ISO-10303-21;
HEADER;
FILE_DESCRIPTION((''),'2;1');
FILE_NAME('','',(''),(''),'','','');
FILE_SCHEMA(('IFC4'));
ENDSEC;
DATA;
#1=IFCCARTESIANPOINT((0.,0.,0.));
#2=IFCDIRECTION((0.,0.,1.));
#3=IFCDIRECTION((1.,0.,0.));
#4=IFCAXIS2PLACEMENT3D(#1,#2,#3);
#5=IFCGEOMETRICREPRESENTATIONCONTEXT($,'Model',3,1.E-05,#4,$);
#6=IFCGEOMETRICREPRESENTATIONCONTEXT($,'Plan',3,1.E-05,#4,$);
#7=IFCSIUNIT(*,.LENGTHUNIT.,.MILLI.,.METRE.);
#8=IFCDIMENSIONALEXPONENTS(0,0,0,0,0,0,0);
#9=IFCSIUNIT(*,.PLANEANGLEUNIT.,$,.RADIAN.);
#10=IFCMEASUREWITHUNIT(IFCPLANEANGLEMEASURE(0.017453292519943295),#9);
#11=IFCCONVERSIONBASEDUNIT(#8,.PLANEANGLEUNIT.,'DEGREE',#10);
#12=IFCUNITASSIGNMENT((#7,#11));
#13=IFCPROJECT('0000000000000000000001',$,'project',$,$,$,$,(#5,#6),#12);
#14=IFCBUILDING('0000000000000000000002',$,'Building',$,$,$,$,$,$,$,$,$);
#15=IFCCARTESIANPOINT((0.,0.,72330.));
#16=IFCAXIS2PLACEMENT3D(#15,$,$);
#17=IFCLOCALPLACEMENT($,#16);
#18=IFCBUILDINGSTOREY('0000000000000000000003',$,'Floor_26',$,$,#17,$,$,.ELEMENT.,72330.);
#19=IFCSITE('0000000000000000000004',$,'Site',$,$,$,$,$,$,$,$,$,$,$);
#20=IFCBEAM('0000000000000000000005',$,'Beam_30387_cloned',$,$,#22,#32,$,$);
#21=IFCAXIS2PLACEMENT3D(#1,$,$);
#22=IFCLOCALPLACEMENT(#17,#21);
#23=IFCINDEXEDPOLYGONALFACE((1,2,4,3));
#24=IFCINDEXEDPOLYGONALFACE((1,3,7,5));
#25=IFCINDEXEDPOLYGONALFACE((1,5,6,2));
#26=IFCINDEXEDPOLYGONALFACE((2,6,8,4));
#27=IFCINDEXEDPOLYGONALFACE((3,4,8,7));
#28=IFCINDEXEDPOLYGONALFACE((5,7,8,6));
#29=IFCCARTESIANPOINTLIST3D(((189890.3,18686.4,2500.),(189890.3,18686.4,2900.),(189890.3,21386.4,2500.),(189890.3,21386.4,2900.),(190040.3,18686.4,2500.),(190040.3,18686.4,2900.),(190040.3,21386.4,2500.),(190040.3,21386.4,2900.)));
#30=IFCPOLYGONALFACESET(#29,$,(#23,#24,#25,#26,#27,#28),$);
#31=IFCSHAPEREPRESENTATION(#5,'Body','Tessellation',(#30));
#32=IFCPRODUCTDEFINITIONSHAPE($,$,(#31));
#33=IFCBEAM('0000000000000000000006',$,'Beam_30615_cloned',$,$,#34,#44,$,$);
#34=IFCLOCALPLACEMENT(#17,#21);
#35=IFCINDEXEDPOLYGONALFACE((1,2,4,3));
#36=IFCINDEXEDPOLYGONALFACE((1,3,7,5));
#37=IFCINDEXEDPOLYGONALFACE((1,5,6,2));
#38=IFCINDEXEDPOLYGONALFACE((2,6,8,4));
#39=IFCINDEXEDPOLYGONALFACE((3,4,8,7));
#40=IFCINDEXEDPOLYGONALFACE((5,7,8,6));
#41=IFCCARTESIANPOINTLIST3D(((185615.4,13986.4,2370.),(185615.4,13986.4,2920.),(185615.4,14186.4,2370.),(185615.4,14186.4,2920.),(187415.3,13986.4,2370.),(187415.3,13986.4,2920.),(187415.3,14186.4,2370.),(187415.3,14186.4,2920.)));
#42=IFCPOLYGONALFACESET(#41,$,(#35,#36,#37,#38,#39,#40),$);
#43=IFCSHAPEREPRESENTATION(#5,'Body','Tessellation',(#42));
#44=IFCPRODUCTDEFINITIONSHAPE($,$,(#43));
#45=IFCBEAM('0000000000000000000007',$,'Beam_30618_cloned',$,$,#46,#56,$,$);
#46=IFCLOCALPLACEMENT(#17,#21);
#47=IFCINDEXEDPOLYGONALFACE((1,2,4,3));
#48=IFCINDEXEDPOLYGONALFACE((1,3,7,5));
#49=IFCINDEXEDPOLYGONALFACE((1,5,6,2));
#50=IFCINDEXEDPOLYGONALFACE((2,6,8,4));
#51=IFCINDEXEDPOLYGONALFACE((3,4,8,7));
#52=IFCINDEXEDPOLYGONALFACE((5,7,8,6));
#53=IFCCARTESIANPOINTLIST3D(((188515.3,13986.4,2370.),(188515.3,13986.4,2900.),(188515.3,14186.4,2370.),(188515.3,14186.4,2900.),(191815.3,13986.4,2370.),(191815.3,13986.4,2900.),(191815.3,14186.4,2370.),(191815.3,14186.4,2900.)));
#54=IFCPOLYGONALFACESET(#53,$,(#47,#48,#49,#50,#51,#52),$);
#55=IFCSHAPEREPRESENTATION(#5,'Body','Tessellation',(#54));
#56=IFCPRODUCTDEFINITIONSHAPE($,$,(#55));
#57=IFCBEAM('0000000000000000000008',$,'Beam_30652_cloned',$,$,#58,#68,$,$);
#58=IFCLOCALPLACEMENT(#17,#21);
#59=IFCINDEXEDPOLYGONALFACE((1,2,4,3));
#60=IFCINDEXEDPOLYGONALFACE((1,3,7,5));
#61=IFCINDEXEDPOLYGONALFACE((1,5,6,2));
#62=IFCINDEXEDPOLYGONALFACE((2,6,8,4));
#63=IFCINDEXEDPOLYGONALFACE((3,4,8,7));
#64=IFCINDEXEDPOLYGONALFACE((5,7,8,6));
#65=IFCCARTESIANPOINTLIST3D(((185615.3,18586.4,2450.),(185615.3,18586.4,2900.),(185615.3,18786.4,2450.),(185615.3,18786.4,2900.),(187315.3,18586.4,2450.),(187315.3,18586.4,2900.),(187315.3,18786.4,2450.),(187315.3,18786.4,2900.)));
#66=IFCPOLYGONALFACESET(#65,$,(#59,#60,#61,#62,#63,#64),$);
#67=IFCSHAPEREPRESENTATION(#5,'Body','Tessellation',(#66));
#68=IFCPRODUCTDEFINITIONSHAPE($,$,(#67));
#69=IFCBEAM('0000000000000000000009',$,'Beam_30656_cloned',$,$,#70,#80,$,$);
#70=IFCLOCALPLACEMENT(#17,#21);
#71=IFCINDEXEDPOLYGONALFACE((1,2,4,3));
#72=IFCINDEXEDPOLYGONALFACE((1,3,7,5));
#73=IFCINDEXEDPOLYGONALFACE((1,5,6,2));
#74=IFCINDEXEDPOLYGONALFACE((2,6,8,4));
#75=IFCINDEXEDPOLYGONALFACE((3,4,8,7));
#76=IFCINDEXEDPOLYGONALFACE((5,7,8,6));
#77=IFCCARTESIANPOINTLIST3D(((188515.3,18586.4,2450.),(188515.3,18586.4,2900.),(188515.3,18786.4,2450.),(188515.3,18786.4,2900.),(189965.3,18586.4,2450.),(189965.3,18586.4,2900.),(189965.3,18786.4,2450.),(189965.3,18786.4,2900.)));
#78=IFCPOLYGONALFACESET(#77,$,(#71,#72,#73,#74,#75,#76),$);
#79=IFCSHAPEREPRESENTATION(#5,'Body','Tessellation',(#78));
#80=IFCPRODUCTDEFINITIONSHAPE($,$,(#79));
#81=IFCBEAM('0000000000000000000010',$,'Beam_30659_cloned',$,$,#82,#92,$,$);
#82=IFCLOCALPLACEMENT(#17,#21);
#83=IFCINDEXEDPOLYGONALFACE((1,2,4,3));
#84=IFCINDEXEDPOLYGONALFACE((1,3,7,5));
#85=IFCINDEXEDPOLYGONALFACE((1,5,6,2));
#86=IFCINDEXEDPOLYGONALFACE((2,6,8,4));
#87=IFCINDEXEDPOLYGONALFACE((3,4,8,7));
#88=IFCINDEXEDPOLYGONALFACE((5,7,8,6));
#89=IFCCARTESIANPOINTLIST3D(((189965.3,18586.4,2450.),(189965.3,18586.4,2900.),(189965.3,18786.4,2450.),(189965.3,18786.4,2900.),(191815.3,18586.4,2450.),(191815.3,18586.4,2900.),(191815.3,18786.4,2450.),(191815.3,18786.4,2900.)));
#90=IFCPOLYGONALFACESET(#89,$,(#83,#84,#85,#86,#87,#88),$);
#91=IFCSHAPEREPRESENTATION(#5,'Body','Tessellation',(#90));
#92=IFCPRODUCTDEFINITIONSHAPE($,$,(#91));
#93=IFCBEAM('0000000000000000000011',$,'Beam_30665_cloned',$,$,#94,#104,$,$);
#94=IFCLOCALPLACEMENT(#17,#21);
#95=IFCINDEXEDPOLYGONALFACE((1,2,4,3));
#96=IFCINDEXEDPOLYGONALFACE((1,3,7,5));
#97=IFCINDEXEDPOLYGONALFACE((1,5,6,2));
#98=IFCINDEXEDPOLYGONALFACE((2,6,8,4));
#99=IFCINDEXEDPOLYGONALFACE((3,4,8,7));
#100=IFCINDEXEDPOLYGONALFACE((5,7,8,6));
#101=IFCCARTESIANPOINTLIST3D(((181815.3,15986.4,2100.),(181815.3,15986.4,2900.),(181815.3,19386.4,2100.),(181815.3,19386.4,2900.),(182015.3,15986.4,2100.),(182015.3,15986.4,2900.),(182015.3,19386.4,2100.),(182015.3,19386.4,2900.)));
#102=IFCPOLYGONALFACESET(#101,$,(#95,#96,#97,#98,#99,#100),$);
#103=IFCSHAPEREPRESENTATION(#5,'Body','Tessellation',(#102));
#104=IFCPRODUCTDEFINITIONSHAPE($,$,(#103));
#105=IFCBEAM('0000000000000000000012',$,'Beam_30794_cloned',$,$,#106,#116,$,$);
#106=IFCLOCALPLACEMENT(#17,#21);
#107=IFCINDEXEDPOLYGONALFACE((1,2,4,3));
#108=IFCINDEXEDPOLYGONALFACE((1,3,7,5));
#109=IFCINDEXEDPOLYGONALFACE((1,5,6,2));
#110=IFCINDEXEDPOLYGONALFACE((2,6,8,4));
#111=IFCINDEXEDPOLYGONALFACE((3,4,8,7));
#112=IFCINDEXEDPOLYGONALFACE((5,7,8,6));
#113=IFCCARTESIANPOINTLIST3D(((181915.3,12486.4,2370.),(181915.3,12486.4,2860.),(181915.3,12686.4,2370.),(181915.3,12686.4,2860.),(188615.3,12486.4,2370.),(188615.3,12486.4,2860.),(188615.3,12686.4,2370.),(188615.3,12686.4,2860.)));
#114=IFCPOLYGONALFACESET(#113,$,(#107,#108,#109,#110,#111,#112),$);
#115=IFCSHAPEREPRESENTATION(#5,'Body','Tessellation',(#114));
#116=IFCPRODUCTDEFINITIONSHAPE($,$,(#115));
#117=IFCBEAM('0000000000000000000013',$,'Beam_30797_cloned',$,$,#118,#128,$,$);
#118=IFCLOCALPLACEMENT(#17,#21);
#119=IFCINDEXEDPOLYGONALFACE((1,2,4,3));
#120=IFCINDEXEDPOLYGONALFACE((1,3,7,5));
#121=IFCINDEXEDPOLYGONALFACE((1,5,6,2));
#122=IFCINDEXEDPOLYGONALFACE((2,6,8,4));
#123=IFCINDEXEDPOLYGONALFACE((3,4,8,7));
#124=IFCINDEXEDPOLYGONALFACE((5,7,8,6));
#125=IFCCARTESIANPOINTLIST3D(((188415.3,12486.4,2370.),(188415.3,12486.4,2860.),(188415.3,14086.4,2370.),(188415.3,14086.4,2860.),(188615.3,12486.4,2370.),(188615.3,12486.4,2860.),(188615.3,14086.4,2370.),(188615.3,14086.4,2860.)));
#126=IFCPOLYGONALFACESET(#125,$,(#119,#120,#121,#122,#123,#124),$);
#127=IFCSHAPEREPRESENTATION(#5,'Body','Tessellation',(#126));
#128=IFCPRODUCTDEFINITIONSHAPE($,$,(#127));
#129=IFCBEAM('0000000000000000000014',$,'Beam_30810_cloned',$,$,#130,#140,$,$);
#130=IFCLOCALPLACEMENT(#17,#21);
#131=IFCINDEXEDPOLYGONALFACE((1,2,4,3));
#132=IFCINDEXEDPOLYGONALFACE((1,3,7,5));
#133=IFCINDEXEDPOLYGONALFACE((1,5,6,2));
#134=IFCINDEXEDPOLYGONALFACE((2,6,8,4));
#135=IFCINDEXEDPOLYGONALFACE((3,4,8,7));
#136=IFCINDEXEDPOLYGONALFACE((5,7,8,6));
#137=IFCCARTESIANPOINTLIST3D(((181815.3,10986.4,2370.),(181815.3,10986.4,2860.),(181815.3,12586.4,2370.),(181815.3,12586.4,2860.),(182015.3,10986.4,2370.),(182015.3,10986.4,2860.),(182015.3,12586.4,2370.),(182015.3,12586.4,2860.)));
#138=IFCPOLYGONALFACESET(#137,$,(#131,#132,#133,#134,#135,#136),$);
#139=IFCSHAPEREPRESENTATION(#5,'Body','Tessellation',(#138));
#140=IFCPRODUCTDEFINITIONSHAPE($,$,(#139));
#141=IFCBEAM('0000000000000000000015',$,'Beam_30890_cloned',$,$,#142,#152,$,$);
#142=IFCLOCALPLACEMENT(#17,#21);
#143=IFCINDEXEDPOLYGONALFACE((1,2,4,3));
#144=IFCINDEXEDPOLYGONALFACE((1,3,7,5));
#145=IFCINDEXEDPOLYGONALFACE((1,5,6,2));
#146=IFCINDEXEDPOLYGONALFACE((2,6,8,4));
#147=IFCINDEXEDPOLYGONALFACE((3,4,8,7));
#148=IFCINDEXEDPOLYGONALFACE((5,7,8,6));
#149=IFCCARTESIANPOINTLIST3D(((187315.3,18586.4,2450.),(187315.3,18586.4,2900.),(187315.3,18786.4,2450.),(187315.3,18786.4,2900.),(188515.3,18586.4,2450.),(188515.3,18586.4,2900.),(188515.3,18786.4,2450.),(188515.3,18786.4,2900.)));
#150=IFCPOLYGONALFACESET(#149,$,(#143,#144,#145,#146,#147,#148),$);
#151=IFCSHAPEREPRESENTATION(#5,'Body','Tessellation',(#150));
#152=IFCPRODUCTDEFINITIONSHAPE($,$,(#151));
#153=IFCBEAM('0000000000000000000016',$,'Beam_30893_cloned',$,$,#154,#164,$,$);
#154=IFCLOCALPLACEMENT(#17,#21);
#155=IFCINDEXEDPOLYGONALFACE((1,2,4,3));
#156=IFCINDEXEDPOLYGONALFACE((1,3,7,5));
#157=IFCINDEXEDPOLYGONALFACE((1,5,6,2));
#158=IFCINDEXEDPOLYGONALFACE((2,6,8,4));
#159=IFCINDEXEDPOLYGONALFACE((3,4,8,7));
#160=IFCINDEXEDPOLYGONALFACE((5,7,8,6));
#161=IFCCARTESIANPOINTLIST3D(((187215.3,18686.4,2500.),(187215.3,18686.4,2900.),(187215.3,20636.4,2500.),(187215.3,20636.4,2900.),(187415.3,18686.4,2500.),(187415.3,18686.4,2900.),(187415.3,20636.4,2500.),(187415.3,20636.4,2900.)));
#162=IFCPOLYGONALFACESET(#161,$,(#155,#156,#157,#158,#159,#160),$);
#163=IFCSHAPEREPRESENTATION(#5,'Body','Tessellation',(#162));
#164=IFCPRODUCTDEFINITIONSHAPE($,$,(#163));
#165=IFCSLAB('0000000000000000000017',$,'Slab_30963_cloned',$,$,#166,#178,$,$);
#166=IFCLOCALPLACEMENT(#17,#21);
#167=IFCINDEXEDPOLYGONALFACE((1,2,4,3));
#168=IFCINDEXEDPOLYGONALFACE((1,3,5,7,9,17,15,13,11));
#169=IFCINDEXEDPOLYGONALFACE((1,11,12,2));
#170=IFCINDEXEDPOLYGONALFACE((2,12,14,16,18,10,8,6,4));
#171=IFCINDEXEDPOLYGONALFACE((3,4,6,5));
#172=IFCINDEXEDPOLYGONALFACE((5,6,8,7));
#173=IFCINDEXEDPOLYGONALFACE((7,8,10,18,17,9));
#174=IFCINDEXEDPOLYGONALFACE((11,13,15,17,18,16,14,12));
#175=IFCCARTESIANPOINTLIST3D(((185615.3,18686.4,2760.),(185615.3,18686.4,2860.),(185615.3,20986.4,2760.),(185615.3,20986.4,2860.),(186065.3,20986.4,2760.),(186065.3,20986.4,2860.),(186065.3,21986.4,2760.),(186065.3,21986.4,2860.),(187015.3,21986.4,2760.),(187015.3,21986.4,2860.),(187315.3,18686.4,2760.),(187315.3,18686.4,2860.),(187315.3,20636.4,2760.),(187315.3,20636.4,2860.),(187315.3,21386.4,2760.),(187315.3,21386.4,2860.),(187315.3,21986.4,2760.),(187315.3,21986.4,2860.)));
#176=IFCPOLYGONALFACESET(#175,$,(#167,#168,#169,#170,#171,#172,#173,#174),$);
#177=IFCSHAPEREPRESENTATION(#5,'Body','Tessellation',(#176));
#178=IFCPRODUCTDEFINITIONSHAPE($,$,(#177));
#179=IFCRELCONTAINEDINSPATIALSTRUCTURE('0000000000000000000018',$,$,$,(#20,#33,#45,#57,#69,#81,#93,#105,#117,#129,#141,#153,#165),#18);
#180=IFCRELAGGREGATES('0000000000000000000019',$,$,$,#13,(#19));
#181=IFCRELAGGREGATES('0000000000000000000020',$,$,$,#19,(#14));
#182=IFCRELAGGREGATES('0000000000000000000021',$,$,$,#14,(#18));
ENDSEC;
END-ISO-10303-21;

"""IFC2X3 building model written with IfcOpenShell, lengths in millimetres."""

from ifc_helpers import new_model, entity, si_unit, converted_unit, frame, origin_with_axes, origin_2d, place, context, project, spatial, polyline, rectangle, outline, extrude, source, transform, mapped, element, save


model = new_model("IFC2X3")

# Units and contexts
model_context = context("Model", 3, precision=1e-05, world=origin_with_axes())
plan_context = context("Plan", 3, precision=1e-05, world=origin_with_axes())
ifc_project = project(units=[si_unit("LENGTHUNIT", "METRE", prefix="MILLI"), converted_unit("PLANEANGLEUNIT", "DEGREE", entity("IfcPlaneAngleMeasure", 0.017453292519943295), si_unit("PLANEANGLEUNIT", "RADIAN"), dimensions=[0, 0, 0, 0, 0, 0, 0])], contexts=[model_context, plan_context])

# Site, building, storey
site = spatial("IfcSite", under=ifc_project, Name="Site")
building = spatial("IfcBuilding", under=site, Name="Building")
storey_placement = place(None, frame((0.0, 0.0, 72330.0)))
storey = spatial("IfcBuildingStorey", under=building, at=storey_placement, Name="Floor_26", CompositionType="ELEMENT", Elevation=72330.0)

# Beams
shared_shape_1 = source(origin_with_axes(), model_context, "Body", "SweptSolid", [
    extrude(rectangle(XDim=150.0, YDim=400.0, at=origin_2d()), origin_with_axes(), (0.0, 0.0, 1.0), 2700.0),
])
beam_1_placement = place(storey_placement, frame((189965.3, 18686.4, 2700.0), z_axis=(0.0, 2700.0, 0.0), x_axis=(2700.0, 0.0, 0.0)))
element("IfcBeam", 1, at=beam_1_placement, inside=storey, Name="Beam_30387_cloned", context=model_context, shape_type="MappedRepresentation", body=[
    mapped(shared_shape_1, transform((0.0, 0.0, 0.0), x_axis=(1.0, 0.0, 0.0), y_axis=(0.0, 1.0, 0.0), z_axis=(0.0, 0.0, 1.0), scale=1.0)),
])
shared_shape_2 = source(origin_with_axes(), model_context, "Body", "SweptSolid", [
    extrude(rectangle(XDim=200.0, YDim=550.0, at=origin_2d()), origin_with_axes(), (0.0, 0.0, 1.0), 1799.9),
])
beam_2_placement = place(storey_placement, frame((185615.4, 14086.4, 2645.0), z_axis=(1799.945586, 0.0, 0.0), x_axis=(0.0, -1799.945586, 0.0)))
element("IfcBeam", 2, at=beam_2_placement, inside=storey, Name="Beam_30615_cloned", context=model_context, shape_type="MappedRepresentation", body=[
    mapped(shared_shape_2, transform((0.0, 0.0, 0.0), x_axis=(1.0, 0.0, 0.0), y_axis=(0.0, 1.0, 0.0), z_axis=(0.0, 0.0, 1.0), scale=1.0)),
])
shared_shape_3 = source(origin_with_axes(), model_context, "Body", "SweptSolid", [
    extrude(rectangle(XDim=200.0, YDim=530.0, at=origin_2d()), origin_with_axes(), (0.0, 0.0, 1.0), 3300.0),
])
beam_3_placement = place(storey_placement, frame((188515.3, 14086.4, 2635.0), z_axis=(3299.979202, 0.0, 0.0), x_axis=(0.0, -3299.979202, 0.0)))
element("IfcBeam", 3, at=beam_3_placement, inside=storey, Name="Beam_30618_cloned", context=model_context, shape_type="MappedRepresentation", body=[
    mapped(shared_shape_3, transform((0.0, 0.0, 0.0), x_axis=(1.0, 0.0, 0.0), y_axis=(0.0, 1.0, 0.0), z_axis=(0.0, 0.0, 1.0), scale=1.0)),
])
shared_shape_4 = source(origin_with_axes(), model_context, "Body", "SweptSolid", [
    extrude(rectangle(XDim=200.0, YDim=450.0, at=origin_2d()), origin_with_axes(), (0.0, 0.0, 1.0), 1700.0),
])
beam_4_placement = place(storey_placement, frame((185615.3, 18686.4, 2675.0), z_axis=(1700.0, 0.0, 0.0), x_axis=(0.0, -1700.0, 0.0)))
element("IfcBeam", 4, at=beam_4_placement, inside=storey, Name="Beam_30652_cloned", context=model_context, shape_type="MappedRepresentation", body=[
    mapped(shared_shape_4, transform((0.0, 0.0, 0.0), x_axis=(1.0, 0.0, 0.0), y_axis=(0.0, 1.0, 0.0), z_axis=(0.0, 0.0, 1.0), scale=1.0)),
])
shared_shape_5 = source(origin_with_axes(), model_context, "Body", "SweptSolid", [
    extrude(rectangle(XDim=200.0, YDim=450.0, at=origin_2d()), origin_with_axes(), (0.0, 0.0, 1.0), 1450.0),
])
beam_5_placement = place(storey_placement, frame((188515.3, 18686.4, 2675.0), z_axis=(1449.979201, 0.0, 0.0), x_axis=(0.0, -1449.979201, 0.0)))
element("IfcBeam", 5, at=beam_5_placement, inside=storey, Name="Beam_30656_cloned", context=model_context, shape_type="MappedRepresentation", body=[
    mapped(shared_shape_5, transform((0.0, 0.0, 0.0), x_axis=(1.0, 0.0, 0.0), y_axis=(0.0, 1.0, 0.0), z_axis=(0.0, 0.0, 1.0), scale=1.0)),
])
shared_shape_6 = source(origin_with_axes(), model_context, "Body", "SweptSolid", [
    extrude(rectangle(XDim=200.0, YDim=450.0, at=origin_2d()), origin_with_axes(), (0.0, 0.0, 1.0), 1850.0),
])
beam_6_placement = place(storey_placement, frame((189965.3, 18686.4, 2675.0), z_axis=(1850.0, 0.0, 0.0), x_axis=(0.0, -1850.0, 0.0)))
element("IfcBeam", 6, at=beam_6_placement, inside=storey, Name="Beam_30659_cloned", context=model_context, shape_type="MappedRepresentation", body=[
    mapped(shared_shape_6, transform((0.0, 0.0, 0.0), x_axis=(1.0, 0.0, 0.0), y_axis=(0.0, 1.0, 0.0), z_axis=(0.0, 0.0, 1.0), scale=1.0)),
])
shared_shape_7 = source(origin_with_axes(), model_context, "Body", "SweptSolid", [
    extrude(rectangle(XDim=200.0, YDim=800.0, at=origin_2d()), origin_with_axes(), (0.0, 0.0, 1.0), 3400.0),
])
beam_7_placement = place(storey_placement, frame((181915.3, 15986.4, 2500.0), z_axis=(0.0, 3400.000002, 0.0), x_axis=(3400.000002, 0.0, 0.0)))
element("IfcBeam", 7, at=beam_7_placement, inside=storey, Name="Beam_30665_cloned", context=model_context, shape_type="MappedRepresentation", body=[
    mapped(shared_shape_7, transform((0.0, 0.0, 0.0), x_axis=(1.0, 0.0, 0.0), y_axis=(0.0, 1.0, 0.0), z_axis=(0.0, 0.0, 1.0), scale=1.0)),
])
shared_shape_8 = source(origin_with_axes(), model_context, "Body", "SweptSolid", [
    extrude(rectangle(XDim=200.0, YDim=490.0, at=origin_2d()), origin_with_axes(), (0.0, 0.0, 1.0), 6700.0),
])
beam_8_placement = place(storey_placement, frame((181915.3, 12586.4, 2615.0), z_axis=(6700.020798, 0.0, 0.0), x_axis=(0.0, -6700.020798, 0.0)))
element("IfcBeam", 8, at=beam_8_placement, inside=storey, Name="Beam_30794_cloned", context=model_context, shape_type="MappedRepresentation", body=[
    mapped(shared_shape_8, transform((0.0, 0.0, 0.0), x_axis=(1.0, 0.0, 0.0), y_axis=(0.0, 1.0, 0.0), z_axis=(0.0, 0.0, 1.0), scale=1.0)),
])
shared_shape_9 = source(origin_with_axes(), model_context, "Body", "SweptSolid", [
    extrude(rectangle(XDim=200.0, YDim=490.0, at=origin_2d()), origin_with_axes(), (0.0, 0.0, 1.0), 1600.0),
])
beam_9_placement = place(storey_placement, frame((188515.3, 12486.4, 2615.0), z_axis=(0.0, 1600.000004, 0.0), x_axis=(1600.000004, 0.0, 0.0)))
element("IfcBeam", 9, at=beam_9_placement, inside=storey, Name="Beam_30797_cloned", context=model_context, shape_type="MappedRepresentation", body=[
    mapped(shared_shape_9, transform((0.0, 0.0, 0.0), x_axis=(1.0, 0.0, 0.0), y_axis=(0.0, 1.0, 0.0), z_axis=(0.0, 0.0, 1.0), scale=1.0)),
])
shared_shape_10 = source(origin_with_axes(), model_context, "Body", "SweptSolid", [
    extrude(rectangle(XDim=200.0, YDim=490.0, at=origin_2d()), origin_with_axes(), (0.0, 0.0, 1.0), 1600.0),
])
beam_10_placement = place(storey_placement, frame((181915.3, 10986.4, 2615.0), z_axis=(0.0, 1600.0, 0.0), x_axis=(1600.0, 0.0, 0.0)))
element("IfcBeam", 10, at=beam_10_placement, inside=storey, Name="Beam_30810_cloned", context=model_context, shape_type="MappedRepresentation", body=[
    mapped(shared_shape_10, transform((0.0, 0.0, 0.0), x_axis=(1.0, 0.0, 0.0), y_axis=(0.0, 1.0, 0.0), z_axis=(0.0, 0.0, 1.0), scale=1.0)),
])
shared_shape_11 = source(origin_with_axes(), model_context, "Body", "SweptSolid", [
    extrude(rectangle(XDim=200.0, YDim=450.0, at=origin_2d()), origin_with_axes(), (0.0, 0.0, 1.0), 1200.0),
])
beam_11_placement = place(storey_placement, frame((187315.3, 18686.4, 2675.0), z_axis=(1200.020799, 0.0, 0.0), x_axis=(0.0, -1200.020799, 0.0)))
element("IfcBeam", 11, at=beam_11_placement, inside=storey, Name="Beam_30890_cloned", context=model_context, shape_type="MappedRepresentation", body=[
    mapped(shared_shape_11, transform((0.0, 0.0, 0.0), x_axis=(1.0, 0.0, 0.0), y_axis=(0.0, 1.0, 0.0), z_axis=(0.0, 0.0, 1.0), scale=1.0)),
])
shared_shape_12 = source(origin_with_axes(), model_context, "Body", "SweptSolid", [
    extrude(rectangle(XDim=200.0, YDim=400.0, at=origin_2d()), origin_with_axes(), (0.0, 0.0, 1.0), 1950.0),
])
beam_12_placement = place(storey_placement, frame((187315.3, 18686.4, 2700.0), z_axis=(0.0, 1950.0, 0.0), x_axis=(1950.0, 0.0, 0.0)))
element("IfcBeam", 12, at=beam_12_placement, inside=storey, Name="Beam_30893_cloned", context=model_context, shape_type="MappedRepresentation", body=[
    mapped(shared_shape_12, transform((0.0, 0.0, 0.0), x_axis=(1.0, 0.0, 0.0), y_axis=(0.0, 1.0, 0.0), z_axis=(0.0, 0.0, 1.0), scale=1.0)),
])

# Slab
shared_shape_13 = source(origin_with_axes(), model_context, "Body", "SweptSolid", [
    extrude(outline(polyline([(0.0, 0.0), (1700.0, 0.0), (1700.0, 1950.0), (1700.0, 2700.0), (1700.0, 3300.0), (1400.0, 3300.0), (450.0, 3300.0), (450.0, 2300.0), (0.0, 2300.0)])), origin_with_axes(), (0.0, 0.0, 1.0), 100.0),
])
slab_1_placement = place(storey_placement, frame((185615.3, 18686.4, 2760.0), z_axis=(0.0, 0.0, 1.0), x_axis=(1700.0, 0.0, 0.0)))
element("IfcSlab", 13, at=slab_1_placement, inside=storey, Name="Slab_30963_cloned", context=model_context, shape_type="MappedRepresentation", body=[
    mapped(shared_shape_13, transform((0.0, 0.0, 0.0), x_axis=(1.0, 0.0, 0.0), y_axis=(0.0, 1.0, 0.0), z_axis=(0.0, 0.0, 1.0), scale=1.0)),
])

save(model, "model.ifc")
